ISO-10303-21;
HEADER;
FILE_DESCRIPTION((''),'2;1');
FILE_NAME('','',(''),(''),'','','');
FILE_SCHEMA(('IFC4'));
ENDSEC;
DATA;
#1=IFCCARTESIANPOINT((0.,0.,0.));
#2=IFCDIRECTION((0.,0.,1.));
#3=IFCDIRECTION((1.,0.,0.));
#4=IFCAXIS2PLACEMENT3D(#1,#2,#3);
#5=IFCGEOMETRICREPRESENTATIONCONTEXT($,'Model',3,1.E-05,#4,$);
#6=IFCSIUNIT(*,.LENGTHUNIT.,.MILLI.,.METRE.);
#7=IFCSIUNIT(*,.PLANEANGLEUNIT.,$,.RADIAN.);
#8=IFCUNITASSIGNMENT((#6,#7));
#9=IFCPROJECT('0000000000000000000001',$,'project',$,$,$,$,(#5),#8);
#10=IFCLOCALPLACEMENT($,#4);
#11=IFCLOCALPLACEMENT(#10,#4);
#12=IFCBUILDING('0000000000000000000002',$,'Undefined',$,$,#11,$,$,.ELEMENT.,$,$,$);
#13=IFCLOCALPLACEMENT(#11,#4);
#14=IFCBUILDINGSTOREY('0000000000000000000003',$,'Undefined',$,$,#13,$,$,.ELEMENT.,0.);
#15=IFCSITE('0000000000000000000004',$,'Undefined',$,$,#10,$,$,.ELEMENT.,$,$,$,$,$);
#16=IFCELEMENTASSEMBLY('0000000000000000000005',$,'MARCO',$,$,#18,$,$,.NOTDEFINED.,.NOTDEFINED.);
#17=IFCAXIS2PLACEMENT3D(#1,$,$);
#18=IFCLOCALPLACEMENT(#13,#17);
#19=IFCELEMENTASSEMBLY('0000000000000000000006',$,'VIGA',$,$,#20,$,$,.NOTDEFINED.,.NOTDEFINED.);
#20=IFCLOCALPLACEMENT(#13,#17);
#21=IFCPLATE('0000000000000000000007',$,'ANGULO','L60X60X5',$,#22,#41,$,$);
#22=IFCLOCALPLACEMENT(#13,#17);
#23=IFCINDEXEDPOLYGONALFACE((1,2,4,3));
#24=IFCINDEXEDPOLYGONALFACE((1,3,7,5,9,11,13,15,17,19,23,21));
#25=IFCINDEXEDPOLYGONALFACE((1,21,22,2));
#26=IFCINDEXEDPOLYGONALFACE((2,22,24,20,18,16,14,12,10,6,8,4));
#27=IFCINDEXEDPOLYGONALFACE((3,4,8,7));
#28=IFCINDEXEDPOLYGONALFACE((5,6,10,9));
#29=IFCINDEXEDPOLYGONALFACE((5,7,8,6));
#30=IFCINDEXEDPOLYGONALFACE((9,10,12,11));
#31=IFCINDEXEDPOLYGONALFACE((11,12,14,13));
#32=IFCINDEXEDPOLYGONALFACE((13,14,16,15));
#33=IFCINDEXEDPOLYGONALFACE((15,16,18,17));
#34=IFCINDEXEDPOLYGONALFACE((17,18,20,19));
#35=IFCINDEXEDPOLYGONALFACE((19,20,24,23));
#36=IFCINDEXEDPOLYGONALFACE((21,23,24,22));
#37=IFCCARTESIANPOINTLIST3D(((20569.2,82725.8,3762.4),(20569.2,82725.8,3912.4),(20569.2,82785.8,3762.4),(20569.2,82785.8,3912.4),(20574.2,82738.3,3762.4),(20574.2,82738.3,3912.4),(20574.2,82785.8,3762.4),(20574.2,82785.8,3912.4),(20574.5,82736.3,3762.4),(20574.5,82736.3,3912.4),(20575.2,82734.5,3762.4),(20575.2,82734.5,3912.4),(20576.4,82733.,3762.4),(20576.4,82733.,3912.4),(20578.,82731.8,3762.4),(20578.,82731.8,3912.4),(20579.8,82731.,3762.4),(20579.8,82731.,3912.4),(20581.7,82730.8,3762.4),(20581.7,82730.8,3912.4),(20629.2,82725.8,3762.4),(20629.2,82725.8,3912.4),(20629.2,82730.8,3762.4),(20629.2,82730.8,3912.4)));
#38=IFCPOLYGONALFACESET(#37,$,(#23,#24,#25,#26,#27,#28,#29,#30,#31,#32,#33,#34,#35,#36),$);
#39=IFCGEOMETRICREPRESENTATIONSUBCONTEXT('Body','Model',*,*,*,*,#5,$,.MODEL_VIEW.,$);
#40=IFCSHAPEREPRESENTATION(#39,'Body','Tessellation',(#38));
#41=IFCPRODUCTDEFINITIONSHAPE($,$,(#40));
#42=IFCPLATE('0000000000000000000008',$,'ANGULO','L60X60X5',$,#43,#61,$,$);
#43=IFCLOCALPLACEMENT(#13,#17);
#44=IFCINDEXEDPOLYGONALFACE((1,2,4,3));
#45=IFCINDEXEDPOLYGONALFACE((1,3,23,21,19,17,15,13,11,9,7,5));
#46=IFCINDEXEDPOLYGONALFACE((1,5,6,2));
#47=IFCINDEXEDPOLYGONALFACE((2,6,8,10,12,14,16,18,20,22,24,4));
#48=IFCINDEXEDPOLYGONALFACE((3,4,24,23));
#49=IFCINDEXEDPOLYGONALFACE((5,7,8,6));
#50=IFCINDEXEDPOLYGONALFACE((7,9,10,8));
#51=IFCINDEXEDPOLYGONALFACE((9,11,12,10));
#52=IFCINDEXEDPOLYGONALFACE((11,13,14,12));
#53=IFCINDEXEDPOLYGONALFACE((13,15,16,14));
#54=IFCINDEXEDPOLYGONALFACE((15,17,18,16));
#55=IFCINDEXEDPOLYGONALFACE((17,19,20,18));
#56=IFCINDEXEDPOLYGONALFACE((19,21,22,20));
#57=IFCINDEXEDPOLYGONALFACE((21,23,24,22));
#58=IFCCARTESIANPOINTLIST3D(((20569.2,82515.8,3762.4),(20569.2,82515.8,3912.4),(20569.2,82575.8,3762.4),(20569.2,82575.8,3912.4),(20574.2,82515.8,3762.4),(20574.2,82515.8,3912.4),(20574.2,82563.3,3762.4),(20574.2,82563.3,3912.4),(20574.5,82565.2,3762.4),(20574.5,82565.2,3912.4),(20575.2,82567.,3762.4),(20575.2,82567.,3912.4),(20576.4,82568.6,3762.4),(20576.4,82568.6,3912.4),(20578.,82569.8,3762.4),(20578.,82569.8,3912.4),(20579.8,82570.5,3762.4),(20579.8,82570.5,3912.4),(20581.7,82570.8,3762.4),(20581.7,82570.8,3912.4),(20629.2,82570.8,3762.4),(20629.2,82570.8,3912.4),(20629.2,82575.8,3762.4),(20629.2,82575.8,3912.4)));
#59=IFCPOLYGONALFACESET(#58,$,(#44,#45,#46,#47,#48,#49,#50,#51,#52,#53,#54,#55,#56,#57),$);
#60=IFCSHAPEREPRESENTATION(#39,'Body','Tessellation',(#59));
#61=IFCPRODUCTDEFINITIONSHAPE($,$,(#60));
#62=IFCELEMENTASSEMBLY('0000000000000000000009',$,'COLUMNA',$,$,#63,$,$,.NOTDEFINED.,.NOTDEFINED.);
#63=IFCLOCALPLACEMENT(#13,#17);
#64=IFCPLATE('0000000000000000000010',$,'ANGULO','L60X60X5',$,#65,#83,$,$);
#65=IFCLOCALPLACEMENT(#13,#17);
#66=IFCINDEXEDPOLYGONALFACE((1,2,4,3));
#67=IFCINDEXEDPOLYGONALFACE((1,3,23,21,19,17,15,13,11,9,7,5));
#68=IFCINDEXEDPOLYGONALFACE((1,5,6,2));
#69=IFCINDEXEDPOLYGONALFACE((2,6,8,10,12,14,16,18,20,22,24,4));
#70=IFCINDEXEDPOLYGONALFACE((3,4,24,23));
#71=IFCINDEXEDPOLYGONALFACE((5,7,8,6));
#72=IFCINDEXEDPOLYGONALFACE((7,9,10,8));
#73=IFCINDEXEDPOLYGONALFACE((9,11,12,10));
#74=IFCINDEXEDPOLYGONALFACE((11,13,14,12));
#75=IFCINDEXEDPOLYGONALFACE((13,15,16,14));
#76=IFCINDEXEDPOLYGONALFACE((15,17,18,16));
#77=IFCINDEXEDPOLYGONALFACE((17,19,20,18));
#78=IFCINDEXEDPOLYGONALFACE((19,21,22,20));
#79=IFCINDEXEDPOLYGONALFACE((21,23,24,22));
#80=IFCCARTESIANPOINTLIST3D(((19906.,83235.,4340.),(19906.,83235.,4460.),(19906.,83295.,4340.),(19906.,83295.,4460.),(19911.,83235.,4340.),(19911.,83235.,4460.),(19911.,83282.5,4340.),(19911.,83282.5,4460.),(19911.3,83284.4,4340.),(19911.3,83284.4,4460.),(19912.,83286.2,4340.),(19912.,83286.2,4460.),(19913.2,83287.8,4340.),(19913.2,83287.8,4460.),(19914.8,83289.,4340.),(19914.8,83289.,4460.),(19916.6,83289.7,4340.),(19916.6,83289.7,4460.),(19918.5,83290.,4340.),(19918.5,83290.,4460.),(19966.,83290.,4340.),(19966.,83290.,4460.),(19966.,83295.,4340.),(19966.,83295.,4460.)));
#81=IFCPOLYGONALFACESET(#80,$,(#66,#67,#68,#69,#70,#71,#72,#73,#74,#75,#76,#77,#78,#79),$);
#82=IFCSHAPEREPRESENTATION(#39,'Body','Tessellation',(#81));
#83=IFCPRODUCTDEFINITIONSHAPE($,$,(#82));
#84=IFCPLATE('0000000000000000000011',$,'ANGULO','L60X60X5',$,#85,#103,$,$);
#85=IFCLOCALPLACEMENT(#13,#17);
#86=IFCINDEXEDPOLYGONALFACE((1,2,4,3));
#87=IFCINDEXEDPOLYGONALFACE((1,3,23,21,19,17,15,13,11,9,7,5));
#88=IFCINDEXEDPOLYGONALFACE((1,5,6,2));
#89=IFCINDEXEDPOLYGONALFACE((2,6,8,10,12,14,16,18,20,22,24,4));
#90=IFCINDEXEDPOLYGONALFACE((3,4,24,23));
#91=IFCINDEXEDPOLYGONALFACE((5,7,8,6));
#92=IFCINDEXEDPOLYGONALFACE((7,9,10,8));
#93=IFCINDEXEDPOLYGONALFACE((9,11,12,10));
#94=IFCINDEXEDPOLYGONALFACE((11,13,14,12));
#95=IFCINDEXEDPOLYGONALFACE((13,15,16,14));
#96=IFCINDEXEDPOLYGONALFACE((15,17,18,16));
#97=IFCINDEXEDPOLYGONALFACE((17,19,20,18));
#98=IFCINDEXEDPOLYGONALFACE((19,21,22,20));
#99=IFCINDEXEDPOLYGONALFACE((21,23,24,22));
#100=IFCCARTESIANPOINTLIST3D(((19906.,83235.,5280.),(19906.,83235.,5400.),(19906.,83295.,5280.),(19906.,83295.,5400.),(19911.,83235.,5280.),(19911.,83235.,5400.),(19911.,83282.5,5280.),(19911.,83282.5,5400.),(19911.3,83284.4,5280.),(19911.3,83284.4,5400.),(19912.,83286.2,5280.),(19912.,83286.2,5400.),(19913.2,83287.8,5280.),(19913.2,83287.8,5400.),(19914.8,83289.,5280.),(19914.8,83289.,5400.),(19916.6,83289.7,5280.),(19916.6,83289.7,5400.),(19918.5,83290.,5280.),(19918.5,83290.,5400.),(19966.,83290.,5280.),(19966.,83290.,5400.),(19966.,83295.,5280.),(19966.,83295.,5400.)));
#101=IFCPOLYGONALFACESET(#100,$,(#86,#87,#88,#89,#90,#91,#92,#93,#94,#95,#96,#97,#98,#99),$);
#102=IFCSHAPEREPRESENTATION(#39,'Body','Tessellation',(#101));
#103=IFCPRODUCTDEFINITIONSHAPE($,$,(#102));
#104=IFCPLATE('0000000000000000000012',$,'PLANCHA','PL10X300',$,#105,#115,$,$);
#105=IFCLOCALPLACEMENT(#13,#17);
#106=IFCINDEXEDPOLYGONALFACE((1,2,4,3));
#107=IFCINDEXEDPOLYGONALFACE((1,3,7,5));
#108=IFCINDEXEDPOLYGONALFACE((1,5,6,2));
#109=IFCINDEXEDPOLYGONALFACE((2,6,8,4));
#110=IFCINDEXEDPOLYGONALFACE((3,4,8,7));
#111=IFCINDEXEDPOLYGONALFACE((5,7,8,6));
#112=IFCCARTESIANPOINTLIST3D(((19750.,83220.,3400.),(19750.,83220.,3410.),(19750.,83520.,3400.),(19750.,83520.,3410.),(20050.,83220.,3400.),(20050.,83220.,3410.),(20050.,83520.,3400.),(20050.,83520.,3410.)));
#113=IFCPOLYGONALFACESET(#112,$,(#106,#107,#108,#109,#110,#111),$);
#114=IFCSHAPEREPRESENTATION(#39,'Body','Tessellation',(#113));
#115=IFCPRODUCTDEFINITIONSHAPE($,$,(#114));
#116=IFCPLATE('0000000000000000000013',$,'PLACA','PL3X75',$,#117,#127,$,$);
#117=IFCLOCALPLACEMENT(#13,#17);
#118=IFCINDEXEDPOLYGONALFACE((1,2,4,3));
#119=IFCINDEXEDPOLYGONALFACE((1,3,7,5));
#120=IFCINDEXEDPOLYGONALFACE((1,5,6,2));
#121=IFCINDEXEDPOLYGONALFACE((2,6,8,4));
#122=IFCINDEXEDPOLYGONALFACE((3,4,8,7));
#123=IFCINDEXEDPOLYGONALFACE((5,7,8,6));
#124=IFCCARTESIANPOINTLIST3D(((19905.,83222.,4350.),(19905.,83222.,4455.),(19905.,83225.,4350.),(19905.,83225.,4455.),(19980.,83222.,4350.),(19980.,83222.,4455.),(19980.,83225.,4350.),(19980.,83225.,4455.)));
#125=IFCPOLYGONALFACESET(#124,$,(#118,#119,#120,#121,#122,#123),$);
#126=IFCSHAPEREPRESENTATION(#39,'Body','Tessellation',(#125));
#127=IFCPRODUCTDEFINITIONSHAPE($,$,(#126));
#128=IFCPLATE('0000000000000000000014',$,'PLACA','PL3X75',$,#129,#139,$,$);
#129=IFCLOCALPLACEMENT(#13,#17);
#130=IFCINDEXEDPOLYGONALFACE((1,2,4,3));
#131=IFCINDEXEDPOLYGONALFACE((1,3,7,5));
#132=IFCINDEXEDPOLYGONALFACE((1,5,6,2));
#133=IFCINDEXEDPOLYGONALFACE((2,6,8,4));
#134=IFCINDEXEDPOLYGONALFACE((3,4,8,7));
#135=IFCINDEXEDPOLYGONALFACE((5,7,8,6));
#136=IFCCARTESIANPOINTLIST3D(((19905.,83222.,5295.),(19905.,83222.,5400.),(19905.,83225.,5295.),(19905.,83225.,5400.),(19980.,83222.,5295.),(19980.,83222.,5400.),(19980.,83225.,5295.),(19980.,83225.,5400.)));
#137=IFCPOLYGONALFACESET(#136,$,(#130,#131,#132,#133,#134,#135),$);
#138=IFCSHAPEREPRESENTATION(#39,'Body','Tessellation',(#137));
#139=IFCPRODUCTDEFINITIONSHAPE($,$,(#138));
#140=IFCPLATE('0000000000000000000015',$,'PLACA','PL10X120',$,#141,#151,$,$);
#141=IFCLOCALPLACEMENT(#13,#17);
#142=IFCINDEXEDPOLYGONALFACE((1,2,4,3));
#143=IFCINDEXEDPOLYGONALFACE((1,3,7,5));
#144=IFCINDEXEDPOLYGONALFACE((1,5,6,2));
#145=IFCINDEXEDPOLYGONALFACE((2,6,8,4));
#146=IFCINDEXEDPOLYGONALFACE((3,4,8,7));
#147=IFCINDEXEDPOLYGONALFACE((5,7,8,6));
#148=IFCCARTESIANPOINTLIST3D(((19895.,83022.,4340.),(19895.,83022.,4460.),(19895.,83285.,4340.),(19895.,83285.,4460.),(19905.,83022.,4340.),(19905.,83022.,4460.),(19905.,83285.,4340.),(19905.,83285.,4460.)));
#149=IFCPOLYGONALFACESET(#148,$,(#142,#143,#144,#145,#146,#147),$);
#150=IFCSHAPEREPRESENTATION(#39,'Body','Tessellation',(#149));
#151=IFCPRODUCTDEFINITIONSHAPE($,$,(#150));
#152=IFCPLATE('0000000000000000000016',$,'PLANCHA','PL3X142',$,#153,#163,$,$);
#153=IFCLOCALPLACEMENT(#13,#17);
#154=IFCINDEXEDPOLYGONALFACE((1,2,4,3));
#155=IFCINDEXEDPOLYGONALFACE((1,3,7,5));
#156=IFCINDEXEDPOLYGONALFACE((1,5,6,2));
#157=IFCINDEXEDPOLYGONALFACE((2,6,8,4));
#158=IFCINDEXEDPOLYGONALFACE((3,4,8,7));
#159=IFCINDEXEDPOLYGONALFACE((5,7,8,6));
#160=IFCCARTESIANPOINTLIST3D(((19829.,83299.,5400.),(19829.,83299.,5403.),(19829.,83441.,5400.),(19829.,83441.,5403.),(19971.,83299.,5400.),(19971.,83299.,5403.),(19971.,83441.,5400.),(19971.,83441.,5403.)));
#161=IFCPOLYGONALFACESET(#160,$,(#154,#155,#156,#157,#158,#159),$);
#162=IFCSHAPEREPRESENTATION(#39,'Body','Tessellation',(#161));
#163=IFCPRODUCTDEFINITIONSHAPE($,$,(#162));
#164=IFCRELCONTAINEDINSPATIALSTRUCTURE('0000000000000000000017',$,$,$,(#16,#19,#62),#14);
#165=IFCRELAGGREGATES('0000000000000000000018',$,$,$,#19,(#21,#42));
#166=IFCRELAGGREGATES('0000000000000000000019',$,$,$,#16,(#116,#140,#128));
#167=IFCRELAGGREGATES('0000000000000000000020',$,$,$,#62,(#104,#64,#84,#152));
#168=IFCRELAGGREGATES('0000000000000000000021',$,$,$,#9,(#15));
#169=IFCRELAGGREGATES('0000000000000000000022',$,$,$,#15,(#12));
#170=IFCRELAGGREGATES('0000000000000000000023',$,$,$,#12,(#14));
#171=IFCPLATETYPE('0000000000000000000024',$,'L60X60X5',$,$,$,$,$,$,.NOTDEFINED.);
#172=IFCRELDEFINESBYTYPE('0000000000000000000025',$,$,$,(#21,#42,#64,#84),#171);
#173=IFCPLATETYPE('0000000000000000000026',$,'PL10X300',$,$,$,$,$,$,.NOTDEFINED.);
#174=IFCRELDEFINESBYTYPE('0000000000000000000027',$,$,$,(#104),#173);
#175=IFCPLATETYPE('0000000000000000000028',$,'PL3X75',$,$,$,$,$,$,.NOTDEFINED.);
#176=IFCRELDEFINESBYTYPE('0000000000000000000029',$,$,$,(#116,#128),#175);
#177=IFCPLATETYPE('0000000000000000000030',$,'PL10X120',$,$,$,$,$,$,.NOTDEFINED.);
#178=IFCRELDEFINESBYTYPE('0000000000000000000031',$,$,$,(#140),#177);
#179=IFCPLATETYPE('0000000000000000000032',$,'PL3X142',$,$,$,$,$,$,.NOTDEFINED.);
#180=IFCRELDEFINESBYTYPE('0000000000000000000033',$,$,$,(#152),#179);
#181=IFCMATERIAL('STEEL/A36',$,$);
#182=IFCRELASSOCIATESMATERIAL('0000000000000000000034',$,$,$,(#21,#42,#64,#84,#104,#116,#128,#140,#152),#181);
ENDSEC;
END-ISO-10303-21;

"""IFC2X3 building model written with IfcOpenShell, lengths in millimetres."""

from ifc_helpers import new_model, si_unit, frame, origin_with_axes, origin_2d_with_axis, place, context, subcontext, project, spatial, polyline, l_section, outline, extrude, material, type_object, element, aggregate, save


model = new_model("IFC2X3")

# Units and contexts
model_context = context("Model", 3, precision=1e-05, world=origin_with_axes())
body_context = subcontext(model_context, "Body", "Model", "MODEL_VIEW")
ifc_project = project(units=[si_unit("LENGTHUNIT", "METRE", prefix="MILLI"), si_unit("PLANEANGLEUNIT", "RADIAN")], contexts=[model_context])

# Site, building, storey
site_placement = place(None, origin_with_axes())
site = spatial("IfcSite", under=ifc_project, at=site_placement, Name="Undefined", CompositionType="ELEMENT")
building_placement = place(site_placement, origin_with_axes())
building = spatial("IfcBuilding", under=site, at=building_placement, Name="Undefined", CompositionType="ELEMENT")
storey_placement = place(building_placement, origin_with_axes())
storey = spatial("IfcBuildingStorey", under=building, at=storey_placement, Name="Undefined", CompositionType="ELEMENT", Elevation=0.0)

# Element assembly
assembly_1_placement = place(storey_placement, origin_with_axes())
assembly_1 = element("IfcElementAssembly", 1, at=assembly_1_placement, inside=storey, Name="MARCO", AssemblyPlace="NOTDEFINED", PredefinedType="NOTDEFINED")
ifc_material_1 = material(Name="STEEL/A36")

# Element assembly
assembly_2_placement = place(storey_placement, origin_with_axes())
assembly_2 = element("IfcElementAssembly", 2, at=assembly_2_placement, inside=storey, Name="VIGA", AssemblyPlace="NOTDEFINED", PredefinedType="NOTDEFINED")

# Plates
plate_type_1 = type_object("IfcPlateType", Name="L60X60X5", PredefinedType="NOTDEFINED")
plate_1_placement = place(assembly_2_placement, frame((20599.2, 82755.8, 3762.4), z_axis=(1.0, 0.0, 0.0), x_axis=(0.0, 0.0, 1.0)))
plate_1 = element("IfcPlate", 3, at=plate_1_placement, type_object=plate_type_1, material=ifc_material_1, Name="ANGULO", Description="L60X60X5", context=body_context, shape_type="SweptSolid", body=[
    extrude(l_section(Depth=60.0, Width=60.0, Thickness=5.0, FilletRadius=7.5, at=origin_2d_with_axis()), frame((150.0, 0.0, 0.0), z_axis=(-1.0, 0.0, 0.0), x_axis=(0.0, -1.0, 0.0)), (0.0, 0.0, 1.0), 150.0),
])
plate_2_placement = place(assembly_2_placement, frame((20599.2, 82545.8, 3912.4), z_axis=(1.0, 0.0, 0.0), x_axis=(0.0, 0.0, -1.0)))
plate_2 = element("IfcPlate", 4, at=plate_2_placement, type_object=plate_type_1, material=ifc_material_1, Name="ANGULO", Description="L60X60X5", context=body_context, shape_type="SweptSolid", body=[
    extrude(l_section(Depth=60.0, Width=60.0, Thickness=5.0, FilletRadius=7.5, at=origin_2d_with_axis()), frame((150.0, 0.0, 0.0), z_axis=(-1.0, 0.0, 0.0), x_axis=(0.0, -1.0, 0.0)), (0.0, 0.0, 1.0), 150.0),
])
aggregate(assembly_2, [plate_1, plate_2])

# Element assembly, plates
assembly_3_placement = place(storey_placement, origin_with_axes())
assembly_3 = element("IfcElementAssembly", 5, at=assembly_3_placement, inside=storey, Name="COLUMNA", AssemblyPlace="NOTDEFINED", PredefinedType="NOTDEFINED")
plate_3_placement = place(assembly_3_placement, frame((19936.0, 83265.0, 4460.0), z_axis=(1.0, 0.0, 0.0), x_axis=(0.0, 0.0, -1.0)))
plate_3 = element("IfcPlate", 6, at=plate_3_placement, type_object=plate_type_1, material=ifc_material_1, Name="ANGULO", Description="L60X60X5", context=body_context, shape_type="SweptSolid", body=[
    extrude(l_section(Depth=60.0, Width=60.0, Thickness=5.0, FilletRadius=7.5, at=origin_2d_with_axis()), frame((120.0, 0.0, 0.0), z_axis=(-1.0, 0.0, 0.0), x_axis=(0.0, -1.0, 0.0)), (0.0, 0.0, 1.0), 120.0),
])
plate_4_placement = place(assembly_3_placement, frame((19936.0, 83265.0, 5400.0), z_axis=(1.0, 0.0, 0.0), x_axis=(0.0, 0.0, -1.0)))
plate_4 = element("IfcPlate", 7, at=plate_4_placement, type_object=plate_type_1, material=ifc_material_1, Name="ANGULO", Description="L60X60X5", context=body_context, shape_type="SweptSolid", body=[
    extrude(l_section(Depth=60.0, Width=60.0, Thickness=5.0, FilletRadius=7.5, at=origin_2d_with_axis()), frame((120.0, 0.0, 0.0), z_axis=(-1.0, 0.0, 0.0), x_axis=(0.0, -1.0, 0.0)), (0.0, 0.0, 1.0), 120.0),
])
plate_type_2 = type_object("IfcPlateType", Name="PL10X300", PredefinedType="NOTDEFINED")
plate_5_placement = place(assembly_3_placement, frame((20050.0, 83370.0, 3405.0), z_axis=(0.0, 0.0, 1.0), x_axis=(-1.0, 0.0, 0.0)))
plate_5 = element("IfcPlate", 8, at=plate_5_placement, type_object=plate_type_2, material=ifc_material_1, Name="PLANCHA", Description="PL10X300", context=body_context, shape_type="SweptSolid", body=[
    extrude(outline(polyline([(0.0, -150.0), (0.0, 150.0), (300.0, 150.0), (300.0, -150.0), (0.0, -150.0)])), frame((0.0, 0.0, -5.0), z_axis=(0.0, 0.0, 1.0), x_axis=(1.0, 0.0, 0.0)), (0.0, 0.0, 1.0), 10.0),
])

# Plates
plate_type_3 = type_object("IfcPlateType", Name="PL3X75", PredefinedType="NOTDEFINED")
plate_6_placement = place(assembly_1_placement, frame((19980.0, 83223.5, 4455.0), z_axis=(0.0, -1.0, 0.0), x_axis=(-1.0, 0.0, 0.0)))
plate_6 = element("IfcPlate", 9, at=plate_6_placement, type_object=plate_type_3, material=ifc_material_1, Name="PLACA", Description="PL3X75", context=body_context, shape_type="SweptSolid", body=[
    extrude(outline(polyline([(0.0, 0.0), (75.0, 0.0), (75.0, 105.0), (0.0, 105.0), (0.0, 0.0)])), frame((0.0, 0.0, -1.5), z_axis=(0.0, 0.0, 1.0), x_axis=(1.0, 0.0, 0.0)), (0.0, 0.0, 1.0), 3.0),
])
plate_7_placement = place(assembly_1_placement, frame((19905.0, 83223.5, 5295.0), z_axis=(0.0, -1.0, 0.0), x_axis=(1.0, 0.0, 0.0)))
plate_7 = element("IfcPlate", 10, at=plate_7_placement, type_object=plate_type_3, material=ifc_material_1, Name="PLACA", Description="PL3X75", context=body_context, shape_type="SweptSolid", body=[
    extrude(outline(polyline([(0.0, 0.0), (75.0, 0.0), (75.0, 105.0), (0.0, 105.0), (0.0, 0.0)])), frame((0.0, 0.0, -1.5), z_axis=(0.0, 0.0, 1.0), x_axis=(1.0, 0.0, 0.0)), (0.0, 0.0, 1.0), 3.0),
])
plate_type_4 = type_object("IfcPlateType", Name="PL10X120", PredefinedType="NOTDEFINED")
plate_8_placement = place(assembly_1_placement, frame((19900.0, 83285.0, 4400.0), z_axis=(-1.0, 0.0, 0.0), x_axis=(0.0, -1.0, 0.0)))
plate_8 = element("IfcPlate", 11, at=plate_8_placement, type_object=plate_type_4, material=ifc_material_1, Name="PLACA", Description="PL10X120", context=body_context, shape_type="SweptSolid", body=[
    extrude(outline(polyline([(0.0, -60.0), (0.0, 60.0), (263.0, 60.0), (263.0, -60.0), (0.0, -60.0)])), frame((0.0, 0.0, -5.0), z_axis=(0.0, 0.0, 1.0), x_axis=(1.0, 0.0, 0.0)), (0.0, 0.0, 1.0), 10.0),
])
aggregate(assembly_1, [plate_6, plate_8, plate_7])
plate_type_5 = type_object("IfcPlateType", Name="PL3X142", PredefinedType="NOTDEFINED")
plate_9_placement = place(assembly_3_placement, frame((19971.0, 83441.0, 5401.5), z_axis=(0.0, 0.0, -1.0), x_axis=(0.0, -1.0, 0.0)))
plate_9 = element("IfcPlate", 12, at=plate_9_placement, type_object=plate_type_5, material=ifc_material_1, Name="PLANCHA", Description="PL3X142", context=body_context, shape_type="SweptSolid", body=[
    extrude(outline(polyline([(0.0, 0.0), (142.0, 0.0), (142.0, 142.0), (0.0, 142.0), (0.0, 0.0)])), frame((0.0, 0.0, -1.5), z_axis=(0.0, 0.0, 1.0), x_axis=(1.0, 0.0, 0.0)), (0.0, 0.0, 1.0), 3.0),
])

aggregate(assembly_3, [plate_5, plate_3, plate_4, plate_9])

save(model, "model.ifc")
